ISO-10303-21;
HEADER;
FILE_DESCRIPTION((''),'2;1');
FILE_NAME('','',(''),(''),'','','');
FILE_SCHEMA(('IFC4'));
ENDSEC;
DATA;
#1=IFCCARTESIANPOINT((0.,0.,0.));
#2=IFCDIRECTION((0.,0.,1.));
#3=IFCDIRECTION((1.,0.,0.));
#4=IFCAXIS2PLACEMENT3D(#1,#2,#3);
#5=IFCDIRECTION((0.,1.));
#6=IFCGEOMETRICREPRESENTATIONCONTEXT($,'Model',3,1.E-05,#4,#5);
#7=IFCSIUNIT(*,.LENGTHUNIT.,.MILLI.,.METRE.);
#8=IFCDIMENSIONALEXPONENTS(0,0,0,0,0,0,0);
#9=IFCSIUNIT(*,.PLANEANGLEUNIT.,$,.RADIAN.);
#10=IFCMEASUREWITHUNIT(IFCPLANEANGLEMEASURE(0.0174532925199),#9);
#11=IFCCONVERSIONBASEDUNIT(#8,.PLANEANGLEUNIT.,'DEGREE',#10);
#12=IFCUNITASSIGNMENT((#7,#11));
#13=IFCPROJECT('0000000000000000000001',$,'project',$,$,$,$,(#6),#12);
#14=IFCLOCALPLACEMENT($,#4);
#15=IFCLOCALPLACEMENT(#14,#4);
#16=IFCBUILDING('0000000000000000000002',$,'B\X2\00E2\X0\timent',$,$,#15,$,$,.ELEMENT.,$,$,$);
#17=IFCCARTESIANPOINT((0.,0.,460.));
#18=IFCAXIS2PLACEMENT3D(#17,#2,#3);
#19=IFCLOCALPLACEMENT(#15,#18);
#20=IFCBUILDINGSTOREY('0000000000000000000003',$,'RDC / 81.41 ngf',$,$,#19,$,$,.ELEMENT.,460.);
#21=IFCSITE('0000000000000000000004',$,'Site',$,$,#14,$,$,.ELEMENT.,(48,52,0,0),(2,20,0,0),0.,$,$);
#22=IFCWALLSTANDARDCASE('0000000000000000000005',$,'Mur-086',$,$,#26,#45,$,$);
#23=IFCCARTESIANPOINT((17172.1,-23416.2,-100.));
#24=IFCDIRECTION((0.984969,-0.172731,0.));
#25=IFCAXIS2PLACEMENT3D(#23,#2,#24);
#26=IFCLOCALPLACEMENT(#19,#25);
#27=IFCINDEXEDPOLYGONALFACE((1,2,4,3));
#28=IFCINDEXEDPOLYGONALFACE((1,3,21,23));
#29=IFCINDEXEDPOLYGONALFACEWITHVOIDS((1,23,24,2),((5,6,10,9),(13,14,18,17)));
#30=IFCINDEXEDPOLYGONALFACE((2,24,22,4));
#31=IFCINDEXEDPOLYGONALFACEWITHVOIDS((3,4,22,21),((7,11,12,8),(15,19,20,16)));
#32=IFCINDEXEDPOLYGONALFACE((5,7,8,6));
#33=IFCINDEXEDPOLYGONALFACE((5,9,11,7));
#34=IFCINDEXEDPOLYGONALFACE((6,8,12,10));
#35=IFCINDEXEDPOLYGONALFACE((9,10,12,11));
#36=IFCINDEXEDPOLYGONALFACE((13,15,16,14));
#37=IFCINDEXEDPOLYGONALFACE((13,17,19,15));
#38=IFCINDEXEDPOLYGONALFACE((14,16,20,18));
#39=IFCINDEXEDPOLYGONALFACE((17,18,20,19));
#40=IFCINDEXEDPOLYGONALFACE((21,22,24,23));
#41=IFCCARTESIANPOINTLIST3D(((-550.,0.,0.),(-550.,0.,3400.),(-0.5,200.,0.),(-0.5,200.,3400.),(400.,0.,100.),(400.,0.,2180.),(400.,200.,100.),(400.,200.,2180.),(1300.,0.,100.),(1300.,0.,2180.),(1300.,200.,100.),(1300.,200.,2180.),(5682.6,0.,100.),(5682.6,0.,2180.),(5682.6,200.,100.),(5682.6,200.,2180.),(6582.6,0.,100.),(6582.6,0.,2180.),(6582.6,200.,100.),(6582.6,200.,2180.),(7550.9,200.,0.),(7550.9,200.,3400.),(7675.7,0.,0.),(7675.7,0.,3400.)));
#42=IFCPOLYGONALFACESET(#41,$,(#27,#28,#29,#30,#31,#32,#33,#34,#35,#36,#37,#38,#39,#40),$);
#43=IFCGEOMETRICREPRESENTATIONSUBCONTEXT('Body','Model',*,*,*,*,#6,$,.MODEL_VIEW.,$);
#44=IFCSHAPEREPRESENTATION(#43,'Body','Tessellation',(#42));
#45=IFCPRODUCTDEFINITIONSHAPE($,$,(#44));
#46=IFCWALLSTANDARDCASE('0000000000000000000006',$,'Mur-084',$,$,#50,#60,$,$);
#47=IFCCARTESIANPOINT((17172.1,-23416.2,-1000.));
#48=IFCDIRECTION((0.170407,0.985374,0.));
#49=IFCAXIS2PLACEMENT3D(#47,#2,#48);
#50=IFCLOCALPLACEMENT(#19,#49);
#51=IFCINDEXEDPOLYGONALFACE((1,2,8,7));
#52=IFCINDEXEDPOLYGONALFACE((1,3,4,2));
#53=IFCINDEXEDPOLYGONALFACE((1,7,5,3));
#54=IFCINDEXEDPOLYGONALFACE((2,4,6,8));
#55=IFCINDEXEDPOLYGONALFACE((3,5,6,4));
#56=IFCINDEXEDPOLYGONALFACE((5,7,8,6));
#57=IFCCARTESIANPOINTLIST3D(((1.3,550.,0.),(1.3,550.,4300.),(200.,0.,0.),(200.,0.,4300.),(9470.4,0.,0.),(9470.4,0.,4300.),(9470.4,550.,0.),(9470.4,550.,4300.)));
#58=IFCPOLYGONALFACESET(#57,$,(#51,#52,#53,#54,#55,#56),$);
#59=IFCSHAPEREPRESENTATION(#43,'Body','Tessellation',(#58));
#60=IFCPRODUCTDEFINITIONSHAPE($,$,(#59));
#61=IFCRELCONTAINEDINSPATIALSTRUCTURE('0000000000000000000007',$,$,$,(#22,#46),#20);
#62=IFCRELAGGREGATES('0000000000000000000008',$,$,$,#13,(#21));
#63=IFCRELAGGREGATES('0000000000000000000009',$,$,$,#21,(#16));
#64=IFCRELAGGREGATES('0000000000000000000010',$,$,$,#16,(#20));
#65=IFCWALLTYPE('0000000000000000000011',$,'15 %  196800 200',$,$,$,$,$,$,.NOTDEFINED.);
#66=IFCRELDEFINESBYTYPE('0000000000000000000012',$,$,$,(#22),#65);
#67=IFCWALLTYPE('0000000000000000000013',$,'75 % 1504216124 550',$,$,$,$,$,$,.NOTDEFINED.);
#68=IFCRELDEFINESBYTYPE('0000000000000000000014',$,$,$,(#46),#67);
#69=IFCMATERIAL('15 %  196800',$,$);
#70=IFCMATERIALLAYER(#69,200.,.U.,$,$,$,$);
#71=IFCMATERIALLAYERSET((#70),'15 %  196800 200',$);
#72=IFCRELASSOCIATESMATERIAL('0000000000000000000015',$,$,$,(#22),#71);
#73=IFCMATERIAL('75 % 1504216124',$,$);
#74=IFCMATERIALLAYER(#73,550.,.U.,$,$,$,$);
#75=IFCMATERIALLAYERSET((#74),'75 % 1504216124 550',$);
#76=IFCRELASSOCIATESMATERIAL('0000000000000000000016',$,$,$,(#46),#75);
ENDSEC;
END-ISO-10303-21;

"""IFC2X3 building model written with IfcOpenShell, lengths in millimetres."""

from ifc_helpers import new_model, entity, si_unit, converted_unit, direction, frame, origin_with_axes, origin_2d_with_axis, place, context, subcontext, project, spatial, polyline, rectangle, outline, extrude, material, layer, layer_set, layer_usage, type_object, element, save


model = new_model("IFC2X3")

# Units and contexts
model_context = context("Model", 3, precision=1e-05, world=origin_with_axes(), true_north=direction((0.0, 1.0)))
body_context = subcontext(model_context, "Body", "Model", "MODEL_VIEW")
ifc_project = project(units=[si_unit("LENGTHUNIT", "METRE", prefix="MILLI"), converted_unit("PLANEANGLEUNIT", "DEGREE", entity("IfcPlaneAngleMeasure", 0.0174532925199), si_unit("PLANEANGLEUNIT", "RADIAN"), dimensions=[0, 0, 0, 0, 0, 0, 0])], contexts=[model_context])

# Site, building, storey
site_placement = place(None, origin_with_axes())
site = spatial("IfcSite", under=ifc_project, at=site_placement, Name="Site", CompositionType="ELEMENT", RefLatitude=(48, 52, 0, 0), RefLongitude=(2, 20, 0, 0), RefElevation=0.0)
building_placement = place(site_placement, origin_with_axes())
building = spatial("IfcBuilding", under=site, at=building_placement, Name="Bâtiment", CompositionType="ELEMENT")
storey_placement = place(building_placement, frame((0.0, 0.0, 460.0), z_axis=(0.0, 0.0, 1.0), x_axis=(1.0, 0.0, 0.0)))
storey = spatial("IfcBuildingStorey", under=building, at=storey_placement, Name="RDC / 81.41 ngf", CompositionType="ELEMENT", Elevation=460.0)

# Shared definitions
ifc_material_1 = material(Name="15 %  196800")

# Shared definitions
ifc_layer_1 = layer(ifc_material_1, 200.0, ventilated="UNKNOWN")
ifc_layer_set_1 = layer_set([ifc_layer_1], Name="15 %  196800 200")
wall_type_1 = type_object("IfcWallType", Name="15 %  196800 200", PredefinedType="NOTDEFINED")

# Wall, openings
ifc_layer_usage_1 = layer_usage(ifc_layer_set_1, "AXIS2", "NEGATIVE", 200.0)
wall_1_placement = place(storey_placement, frame((17172.1, -23416.2, -100.0), z_axis=(0.0, 0.0, 1.0), x_axis=(0.984969, -0.172731, 0.0)))
wall_1 = element("IfcWallStandardCase", 1, at=wall_1_placement, inside=storey, type_object=wall_type_1, material=ifc_layer_usage_1, Name="Mur-086", context=body_context, shape_type="SweptSolid", body=[
    extrude(outline(polyline([(-550.0, 0.0), (7675.7, 0.0), (7550.9, 200.0), (-0.5, 200.0), (-550.0, 0.0)])), origin_with_axes(), (0.0, 0.0, 1.0), 3400.0),
])
opening_1_placement = place(wall_1_placement, frame((6132.6, 0.0, 100.0), z_axis=(0.0, 0.0, 1.0), x_axis=(1.0, 0.0, 0.0)))
element("IfcOpeningElement", 2, at=opening_1_placement, cuts=wall_1, context=body_context, shape_type="SweptSolid", body=[
    extrude(rectangle(XDim=900.0, YDim=2080.0, at=origin_2d_with_axis()), frame((0.0, -200.0, 1040.0), z_axis=(0.0, -1.0, 0.0), x_axis=(1.0, 0.0, 0.0)), (0.0, 0.0, -1.0), 600.0),
])
opening_2_placement = place(wall_1_placement, frame((850.0, 0.0, 100.0), z_axis=(0.0, 0.0, 1.0), x_axis=(1.0, 0.0, 0.0)))
element("IfcOpeningElement", 3, at=opening_2_placement, cuts=wall_1, context=body_context, shape_type="SweptSolid", body=[
    extrude(rectangle(XDim=900.0, YDim=2080.0, at=origin_2d_with_axis()), frame((0.0, -200.0, 1040.0), z_axis=(0.0, -1.0, 0.0), x_axis=(1.0, 0.0, 0.0)), (0.0, 0.0, -1.0), 600.0),
])

# Wall
ifc_material_2 = material(Name="75 % 1504216124")
ifc_layer_2 = layer(ifc_material_2, 550.0, ventilated="UNKNOWN")
ifc_layer_set_2 = layer_set([ifc_layer_2], Name="75 % 1504216124 550")
ifc_layer_usage_2 = layer_usage(ifc_layer_set_2, "AXIS2", "NEGATIVE", 550.0)
wall_type_2 = type_object("IfcWallType", Name="75 % 1504216124 550", PredefinedType="NOTDEFINED")
wall_2_placement = place(storey_placement, frame((17172.1, -23416.2, -1000.0), z_axis=(0.0, 0.0, 1.0), x_axis=(0.170407, 0.985374, 0.0)))
element("IfcWallStandardCase", 4, at=wall_2_placement, inside=storey, type_object=wall_type_2, material=ifc_layer_usage_2, Name="Mur-084", context=body_context, shape_type="SweptSolid", body=[
    extrude(outline(polyline([(200.0, 0.0), (9470.4, 0.0), (9470.4, 550.0), (1.3, 550.0), (200.0, 0.0)])), origin_with_axes(), (0.0, 0.0, 1.0), 4300.0),
])

save(model, "model.ifc")
